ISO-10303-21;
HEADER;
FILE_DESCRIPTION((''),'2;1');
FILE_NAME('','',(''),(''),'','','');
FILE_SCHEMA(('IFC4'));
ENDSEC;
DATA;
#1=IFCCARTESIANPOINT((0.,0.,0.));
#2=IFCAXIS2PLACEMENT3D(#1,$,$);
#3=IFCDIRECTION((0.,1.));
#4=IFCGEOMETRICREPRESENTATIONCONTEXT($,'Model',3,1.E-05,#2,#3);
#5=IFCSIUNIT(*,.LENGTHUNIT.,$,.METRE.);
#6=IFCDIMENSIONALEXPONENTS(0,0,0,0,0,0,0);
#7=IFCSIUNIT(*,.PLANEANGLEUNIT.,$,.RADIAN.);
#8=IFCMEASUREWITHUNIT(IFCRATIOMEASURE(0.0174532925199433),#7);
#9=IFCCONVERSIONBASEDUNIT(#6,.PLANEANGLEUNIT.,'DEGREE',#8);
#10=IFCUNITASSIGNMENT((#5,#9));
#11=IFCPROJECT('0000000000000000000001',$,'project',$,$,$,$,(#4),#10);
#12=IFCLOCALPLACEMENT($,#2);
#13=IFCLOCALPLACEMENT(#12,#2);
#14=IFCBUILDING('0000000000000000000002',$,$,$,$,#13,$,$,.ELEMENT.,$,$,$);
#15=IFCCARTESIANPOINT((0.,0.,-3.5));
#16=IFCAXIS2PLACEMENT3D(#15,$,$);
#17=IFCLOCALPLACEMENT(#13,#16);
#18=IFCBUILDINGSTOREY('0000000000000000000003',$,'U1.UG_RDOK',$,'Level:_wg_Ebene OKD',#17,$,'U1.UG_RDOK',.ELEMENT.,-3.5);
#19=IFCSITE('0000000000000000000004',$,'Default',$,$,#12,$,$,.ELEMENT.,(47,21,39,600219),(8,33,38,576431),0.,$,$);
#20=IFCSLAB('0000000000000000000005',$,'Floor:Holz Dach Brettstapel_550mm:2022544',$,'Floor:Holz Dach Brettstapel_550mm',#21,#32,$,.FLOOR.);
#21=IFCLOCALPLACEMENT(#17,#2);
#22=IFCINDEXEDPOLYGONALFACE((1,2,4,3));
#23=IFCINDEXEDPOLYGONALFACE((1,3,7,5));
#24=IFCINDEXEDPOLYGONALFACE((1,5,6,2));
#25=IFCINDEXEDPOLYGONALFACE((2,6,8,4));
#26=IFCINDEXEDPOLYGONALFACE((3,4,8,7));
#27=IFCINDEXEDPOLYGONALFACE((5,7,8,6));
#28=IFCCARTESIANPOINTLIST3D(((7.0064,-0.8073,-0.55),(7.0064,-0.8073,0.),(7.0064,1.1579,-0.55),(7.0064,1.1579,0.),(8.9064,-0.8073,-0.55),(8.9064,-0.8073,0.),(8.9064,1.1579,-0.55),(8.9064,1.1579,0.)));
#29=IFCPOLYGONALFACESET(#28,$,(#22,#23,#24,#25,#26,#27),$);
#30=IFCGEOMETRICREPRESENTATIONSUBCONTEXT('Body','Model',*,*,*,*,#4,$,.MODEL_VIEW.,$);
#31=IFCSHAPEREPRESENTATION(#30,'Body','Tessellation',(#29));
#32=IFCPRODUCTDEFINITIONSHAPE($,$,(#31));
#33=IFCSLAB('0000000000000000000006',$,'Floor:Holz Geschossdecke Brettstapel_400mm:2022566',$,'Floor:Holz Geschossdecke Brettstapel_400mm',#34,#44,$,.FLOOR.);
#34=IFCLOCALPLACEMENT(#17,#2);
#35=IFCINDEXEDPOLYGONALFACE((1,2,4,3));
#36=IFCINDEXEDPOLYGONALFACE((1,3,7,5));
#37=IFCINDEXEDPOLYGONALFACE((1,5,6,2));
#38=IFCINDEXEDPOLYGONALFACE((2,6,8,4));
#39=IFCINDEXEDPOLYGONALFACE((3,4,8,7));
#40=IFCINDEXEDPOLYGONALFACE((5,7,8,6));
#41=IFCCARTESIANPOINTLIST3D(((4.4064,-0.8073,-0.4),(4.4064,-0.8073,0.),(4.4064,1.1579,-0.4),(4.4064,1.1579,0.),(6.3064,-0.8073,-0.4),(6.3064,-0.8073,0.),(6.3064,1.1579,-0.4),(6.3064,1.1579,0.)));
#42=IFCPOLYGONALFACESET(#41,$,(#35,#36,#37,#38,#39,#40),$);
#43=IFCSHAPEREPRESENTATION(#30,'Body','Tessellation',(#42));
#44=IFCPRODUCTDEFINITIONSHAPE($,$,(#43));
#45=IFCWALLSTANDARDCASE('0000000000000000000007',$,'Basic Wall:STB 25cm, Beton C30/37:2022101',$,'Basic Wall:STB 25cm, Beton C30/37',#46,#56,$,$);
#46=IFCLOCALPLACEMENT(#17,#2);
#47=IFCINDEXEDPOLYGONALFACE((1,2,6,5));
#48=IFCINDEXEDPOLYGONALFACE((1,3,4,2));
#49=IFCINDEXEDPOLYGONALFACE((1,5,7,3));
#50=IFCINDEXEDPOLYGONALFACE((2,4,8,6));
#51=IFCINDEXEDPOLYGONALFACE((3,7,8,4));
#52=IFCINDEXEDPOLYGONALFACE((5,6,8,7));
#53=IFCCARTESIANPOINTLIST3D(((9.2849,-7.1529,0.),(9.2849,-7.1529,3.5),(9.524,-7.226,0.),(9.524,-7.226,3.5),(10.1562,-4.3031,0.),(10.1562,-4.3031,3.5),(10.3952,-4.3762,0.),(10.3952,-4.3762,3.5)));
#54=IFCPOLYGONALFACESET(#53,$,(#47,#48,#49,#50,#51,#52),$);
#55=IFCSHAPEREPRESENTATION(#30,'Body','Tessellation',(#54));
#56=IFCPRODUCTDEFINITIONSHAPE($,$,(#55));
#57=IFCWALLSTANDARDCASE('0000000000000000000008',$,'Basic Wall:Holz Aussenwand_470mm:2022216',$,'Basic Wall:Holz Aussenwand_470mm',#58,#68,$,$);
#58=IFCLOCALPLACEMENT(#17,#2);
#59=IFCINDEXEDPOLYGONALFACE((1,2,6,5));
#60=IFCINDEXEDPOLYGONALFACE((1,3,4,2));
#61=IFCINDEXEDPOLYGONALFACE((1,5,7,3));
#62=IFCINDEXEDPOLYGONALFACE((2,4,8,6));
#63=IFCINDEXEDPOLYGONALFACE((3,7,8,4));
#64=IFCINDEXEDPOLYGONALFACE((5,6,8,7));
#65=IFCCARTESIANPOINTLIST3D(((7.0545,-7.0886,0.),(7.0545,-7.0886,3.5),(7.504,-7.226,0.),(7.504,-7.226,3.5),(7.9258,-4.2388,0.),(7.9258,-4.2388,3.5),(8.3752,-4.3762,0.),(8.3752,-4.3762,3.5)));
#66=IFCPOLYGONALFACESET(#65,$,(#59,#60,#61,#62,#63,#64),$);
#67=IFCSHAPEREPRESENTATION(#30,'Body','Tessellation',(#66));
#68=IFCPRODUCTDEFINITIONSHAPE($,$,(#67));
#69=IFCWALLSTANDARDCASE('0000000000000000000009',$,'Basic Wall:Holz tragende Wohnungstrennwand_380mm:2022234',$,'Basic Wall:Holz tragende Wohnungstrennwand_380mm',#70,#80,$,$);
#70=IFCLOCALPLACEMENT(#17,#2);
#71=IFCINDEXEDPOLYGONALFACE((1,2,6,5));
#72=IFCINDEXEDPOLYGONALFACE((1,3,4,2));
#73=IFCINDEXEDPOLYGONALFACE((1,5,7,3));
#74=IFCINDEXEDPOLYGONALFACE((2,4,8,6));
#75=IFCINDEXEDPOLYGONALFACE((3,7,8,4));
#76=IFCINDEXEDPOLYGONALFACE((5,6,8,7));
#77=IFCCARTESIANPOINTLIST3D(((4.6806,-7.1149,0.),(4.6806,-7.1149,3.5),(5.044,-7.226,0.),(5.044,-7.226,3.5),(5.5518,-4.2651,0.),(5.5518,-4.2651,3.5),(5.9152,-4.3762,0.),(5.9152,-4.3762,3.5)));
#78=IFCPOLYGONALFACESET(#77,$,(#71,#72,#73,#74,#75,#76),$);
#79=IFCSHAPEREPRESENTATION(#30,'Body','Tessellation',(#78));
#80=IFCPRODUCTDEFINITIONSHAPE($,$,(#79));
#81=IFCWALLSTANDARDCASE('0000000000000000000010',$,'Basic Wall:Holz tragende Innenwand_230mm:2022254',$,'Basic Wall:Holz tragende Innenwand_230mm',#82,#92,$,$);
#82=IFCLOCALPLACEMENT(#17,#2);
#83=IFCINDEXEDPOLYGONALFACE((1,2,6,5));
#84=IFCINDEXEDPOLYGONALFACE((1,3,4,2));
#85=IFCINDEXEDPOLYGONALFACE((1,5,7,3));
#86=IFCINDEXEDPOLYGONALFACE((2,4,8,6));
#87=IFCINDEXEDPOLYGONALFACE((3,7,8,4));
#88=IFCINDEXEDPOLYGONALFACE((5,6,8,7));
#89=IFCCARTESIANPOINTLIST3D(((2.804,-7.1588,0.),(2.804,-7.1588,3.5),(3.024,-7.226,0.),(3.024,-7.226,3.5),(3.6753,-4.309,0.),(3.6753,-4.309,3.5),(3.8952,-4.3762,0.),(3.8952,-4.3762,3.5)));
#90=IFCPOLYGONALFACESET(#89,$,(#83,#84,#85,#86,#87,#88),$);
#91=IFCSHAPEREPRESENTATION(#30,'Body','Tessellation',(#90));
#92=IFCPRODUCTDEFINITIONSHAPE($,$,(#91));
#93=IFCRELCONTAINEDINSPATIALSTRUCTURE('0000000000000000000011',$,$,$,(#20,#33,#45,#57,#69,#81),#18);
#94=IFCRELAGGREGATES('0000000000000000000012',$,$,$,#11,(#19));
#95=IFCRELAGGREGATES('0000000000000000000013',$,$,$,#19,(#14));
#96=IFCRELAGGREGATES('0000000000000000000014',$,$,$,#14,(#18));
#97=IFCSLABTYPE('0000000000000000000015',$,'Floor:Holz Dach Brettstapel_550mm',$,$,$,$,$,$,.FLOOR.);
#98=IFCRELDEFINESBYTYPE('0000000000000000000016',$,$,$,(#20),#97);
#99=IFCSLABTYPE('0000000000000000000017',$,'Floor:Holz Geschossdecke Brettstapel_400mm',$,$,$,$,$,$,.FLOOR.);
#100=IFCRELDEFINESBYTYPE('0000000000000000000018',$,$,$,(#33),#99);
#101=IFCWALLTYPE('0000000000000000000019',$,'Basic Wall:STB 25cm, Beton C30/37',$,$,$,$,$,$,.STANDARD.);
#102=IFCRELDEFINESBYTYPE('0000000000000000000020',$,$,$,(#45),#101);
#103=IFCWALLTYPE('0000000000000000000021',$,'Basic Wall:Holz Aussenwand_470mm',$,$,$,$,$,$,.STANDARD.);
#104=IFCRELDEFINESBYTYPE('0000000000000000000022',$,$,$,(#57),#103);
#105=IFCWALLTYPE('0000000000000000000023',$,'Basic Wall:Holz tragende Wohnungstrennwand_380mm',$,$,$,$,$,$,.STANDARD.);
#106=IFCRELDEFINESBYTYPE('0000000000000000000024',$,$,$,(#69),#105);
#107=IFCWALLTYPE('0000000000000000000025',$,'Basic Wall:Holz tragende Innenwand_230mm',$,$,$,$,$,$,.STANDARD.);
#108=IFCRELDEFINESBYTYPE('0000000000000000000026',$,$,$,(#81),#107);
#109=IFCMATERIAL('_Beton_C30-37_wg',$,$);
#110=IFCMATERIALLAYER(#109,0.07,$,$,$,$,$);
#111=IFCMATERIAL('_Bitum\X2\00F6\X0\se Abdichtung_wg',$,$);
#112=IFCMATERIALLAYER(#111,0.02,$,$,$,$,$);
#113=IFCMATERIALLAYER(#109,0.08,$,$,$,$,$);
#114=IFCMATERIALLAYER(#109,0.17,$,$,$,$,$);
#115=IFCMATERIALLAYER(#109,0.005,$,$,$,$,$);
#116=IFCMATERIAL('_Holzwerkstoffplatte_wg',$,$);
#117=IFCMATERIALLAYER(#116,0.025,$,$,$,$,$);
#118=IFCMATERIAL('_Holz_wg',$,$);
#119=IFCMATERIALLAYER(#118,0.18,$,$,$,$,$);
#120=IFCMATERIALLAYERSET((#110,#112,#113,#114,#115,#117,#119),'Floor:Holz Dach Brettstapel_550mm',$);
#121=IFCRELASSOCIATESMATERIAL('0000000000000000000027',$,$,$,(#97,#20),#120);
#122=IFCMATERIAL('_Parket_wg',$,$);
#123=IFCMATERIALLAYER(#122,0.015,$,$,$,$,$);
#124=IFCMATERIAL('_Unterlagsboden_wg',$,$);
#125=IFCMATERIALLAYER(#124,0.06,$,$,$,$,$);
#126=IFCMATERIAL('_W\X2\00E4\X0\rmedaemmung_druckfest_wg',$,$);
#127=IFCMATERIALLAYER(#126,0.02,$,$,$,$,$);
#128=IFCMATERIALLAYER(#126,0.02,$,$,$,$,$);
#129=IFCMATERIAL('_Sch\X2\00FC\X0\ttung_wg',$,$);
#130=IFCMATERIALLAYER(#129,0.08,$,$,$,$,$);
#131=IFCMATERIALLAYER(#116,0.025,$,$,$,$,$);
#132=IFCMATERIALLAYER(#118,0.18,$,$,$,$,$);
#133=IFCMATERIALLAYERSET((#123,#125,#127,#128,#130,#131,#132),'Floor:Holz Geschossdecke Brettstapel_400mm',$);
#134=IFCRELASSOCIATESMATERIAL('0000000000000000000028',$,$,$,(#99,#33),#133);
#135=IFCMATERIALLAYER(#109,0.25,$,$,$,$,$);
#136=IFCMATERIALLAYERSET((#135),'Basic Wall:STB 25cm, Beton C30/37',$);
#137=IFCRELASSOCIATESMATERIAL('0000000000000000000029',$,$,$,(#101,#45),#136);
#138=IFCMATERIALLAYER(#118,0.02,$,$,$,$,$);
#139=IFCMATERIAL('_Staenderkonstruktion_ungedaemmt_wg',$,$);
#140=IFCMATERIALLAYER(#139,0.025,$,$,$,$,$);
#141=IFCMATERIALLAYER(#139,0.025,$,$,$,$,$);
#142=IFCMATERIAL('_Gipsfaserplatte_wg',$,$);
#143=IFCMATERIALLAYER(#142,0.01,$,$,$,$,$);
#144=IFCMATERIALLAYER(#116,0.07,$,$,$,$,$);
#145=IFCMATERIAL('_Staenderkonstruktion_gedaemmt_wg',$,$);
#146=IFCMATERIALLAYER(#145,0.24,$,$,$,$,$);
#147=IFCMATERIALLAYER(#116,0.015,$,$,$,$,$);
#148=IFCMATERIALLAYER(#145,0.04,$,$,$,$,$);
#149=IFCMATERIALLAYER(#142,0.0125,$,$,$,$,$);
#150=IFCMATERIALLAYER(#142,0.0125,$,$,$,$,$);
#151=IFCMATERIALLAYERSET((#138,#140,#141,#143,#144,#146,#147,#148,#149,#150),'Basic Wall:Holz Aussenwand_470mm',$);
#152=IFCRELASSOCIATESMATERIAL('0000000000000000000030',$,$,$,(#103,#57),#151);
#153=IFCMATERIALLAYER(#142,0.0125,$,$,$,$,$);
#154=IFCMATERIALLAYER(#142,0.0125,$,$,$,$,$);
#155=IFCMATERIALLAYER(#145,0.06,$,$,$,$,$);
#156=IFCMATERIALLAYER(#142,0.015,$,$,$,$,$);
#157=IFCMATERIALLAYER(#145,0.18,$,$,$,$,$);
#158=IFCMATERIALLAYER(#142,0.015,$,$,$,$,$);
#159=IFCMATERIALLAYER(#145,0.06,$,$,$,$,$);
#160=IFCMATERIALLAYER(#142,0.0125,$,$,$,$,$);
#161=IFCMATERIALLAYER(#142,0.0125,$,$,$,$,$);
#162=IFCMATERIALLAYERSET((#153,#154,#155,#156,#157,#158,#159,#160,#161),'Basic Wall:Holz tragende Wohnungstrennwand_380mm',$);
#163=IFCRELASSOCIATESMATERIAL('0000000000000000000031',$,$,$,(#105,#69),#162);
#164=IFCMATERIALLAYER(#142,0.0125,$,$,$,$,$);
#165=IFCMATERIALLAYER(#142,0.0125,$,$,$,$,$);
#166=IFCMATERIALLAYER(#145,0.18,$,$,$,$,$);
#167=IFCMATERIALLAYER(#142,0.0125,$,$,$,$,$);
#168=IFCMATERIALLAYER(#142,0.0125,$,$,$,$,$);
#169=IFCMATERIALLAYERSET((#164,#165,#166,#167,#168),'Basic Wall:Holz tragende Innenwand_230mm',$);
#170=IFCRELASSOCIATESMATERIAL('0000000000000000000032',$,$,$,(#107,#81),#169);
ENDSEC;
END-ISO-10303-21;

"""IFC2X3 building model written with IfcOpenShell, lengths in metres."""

from ifc_helpers import new_model, entity, si_unit, converted_unit, direction, frame, frame_2d, origin, origin_2d_with_axis, place, context, subcontext, project, spatial, rectangle, extrude, material, layer, layer_set, layer_usage, type_object, element, save


model = new_model("IFC2X3")

# Units and contexts
model_context = context("Model", 3, precision=1e-05, world=origin(), true_north=direction((0.0, 1.0)))
body_context = subcontext(model_context, "Body", "Model", "MODEL_VIEW")
ifc_project = project(units=[si_unit("LENGTHUNIT", "METRE"), converted_unit("PLANEANGLEUNIT", "DEGREE", entity("IfcRatioMeasure", 0.0174532925199433), si_unit("PLANEANGLEUNIT", "RADIAN"), dimensions=[0, 0, 0, 0, 0, 0, 0])], contexts=[model_context])

# Site, building, storey
site_placement = place(None, origin())
site = spatial("IfcSite", under=ifc_project, at=site_placement, Name="Default", CompositionType="ELEMENT", RefLatitude=(47, 21, 39, 600219), RefLongitude=(8, 33, 38, 576431), RefElevation=0.0)
building_placement = place(site_placement, origin())
building = spatial("IfcBuilding", under=site, at=building_placement, CompositionType="ELEMENT")
storey_placement = place(building_placement, frame((0.0, 0.0, -3.5)))
storey = spatial("IfcBuildingStorey", under=building, at=storey_placement, Name="U1.UG_RDOK", ObjectType="Level:_wg_Ebene OKD", LongName="U1.UG_RDOK", CompositionType="ELEMENT", Elevation=-3.5)

# Shared definitions
ifc_material_1 = material(Name="_Beton_C30-37_wg")
ifc_material_2 = material(Name="_Holz_wg")

# Slabs
ifc_layer_1 = layer(ifc_material_1, 0.07)
ifc_material_3 = material(Name="_Bitumöse Abdichtung_wg")
ifc_layer_2 = layer(ifc_material_3, 0.02)
ifc_layer_3 = layer(ifc_material_1, 0.08)
ifc_layer_4 = layer(ifc_material_1, 0.17)
ifc_layer_5 = layer(ifc_material_1, 0.005)
ifc_material_4 = material(Name="_Holzwerkstoffplatte_wg")
ifc_layer_6 = layer(ifc_material_4, 0.025)
ifc_layer_7 = layer(ifc_material_2, 0.18)
ifc_layer_set_1 = layer_set([ifc_layer_1, ifc_layer_2, ifc_layer_3, ifc_layer_4, ifc_layer_5, ifc_layer_6, ifc_layer_7], Name="Floor:Holz Dach Brettstapel_550mm")
ifc_layer_usage_1 = layer_usage(ifc_layer_set_1, "AXIS3", "POSITIVE", 0.0)
slab_type_1 = type_object("IfcSlabType", Name="Floor:Holz Dach Brettstapel_550mm", PredefinedType="FLOOR", material=ifc_layer_set_1)
slab_1_placement = place(storey_placement, origin())
element("IfcSlab", 1, at=slab_1_placement, inside=storey, type_object=slab_type_1, material=ifc_layer_usage_1, Name="Floor:Holz Dach Brettstapel_550mm:2022544", ObjectType="Floor:Holz Dach Brettstapel_550mm", PredefinedType="FLOOR", context=body_context, shape_type="SweptSolid", body=[
    extrude(rectangle(XDim=1.9652, YDim=1.9, at=origin_2d_with_axis()), frame((7.9564, 0.1753, 0.0), z_axis=(0.0, 0.0, -1.0), x_axis=(0.0, 1.0, 0.0)), (0.0, 0.0, 1.0), 0.55),
])
ifc_material_5 = material(Name="_Parket_wg")
ifc_layer_8 = layer(ifc_material_5, 0.015)
ifc_material_6 = material(Name="_Unterlagsboden_wg")
ifc_layer_9 = layer(ifc_material_6, 0.06)
ifc_material_7 = material(Name="_Wärmedaemmung_druckfest_wg")
ifc_layer_10 = layer(ifc_material_7, 0.02)
ifc_layer_11 = layer(ifc_material_7, 0.02)
ifc_material_8 = material(Name="_Schüttung_wg")
ifc_layer_12 = layer(ifc_material_8, 0.08)
ifc_layer_13 = layer(ifc_material_4, 0.025)
ifc_layer_14 = layer(ifc_material_2, 0.18)
ifc_layer_set_2 = layer_set([ifc_layer_8, ifc_layer_9, ifc_layer_10, ifc_layer_11, ifc_layer_12, ifc_layer_13, ifc_layer_14], Name="Floor:Holz Geschossdecke Brettstapel_400mm")
ifc_layer_usage_2 = layer_usage(ifc_layer_set_2, "AXIS3", "POSITIVE", 0.0)
slab_type_2 = type_object("IfcSlabType", Name="Floor:Holz Geschossdecke Brettstapel_400mm", PredefinedType="FLOOR", material=ifc_layer_set_2)
slab_2_placement = place(storey_placement, origin())
element("IfcSlab", 2, at=slab_2_placement, inside=storey, type_object=slab_type_2, material=ifc_layer_usage_2, Name="Floor:Holz Geschossdecke Brettstapel_400mm:2022566", ObjectType="Floor:Holz Geschossdecke Brettstapel_400mm", PredefinedType="FLOOR", context=body_context, shape_type="SweptSolid", body=[
    extrude(rectangle(XDim=1.9652, YDim=1.9, at=origin_2d_with_axis()), frame((5.3564, 0.1753, 0.0), z_axis=(0.0, 0.0, -1.0), x_axis=(0.0, 1.0, 0.0)), (0.0, 0.0, 1.0), 0.4),
])

# Walls
ifc_layer_15 = layer(ifc_material_1, 0.25)
ifc_layer_set_3 = layer_set([ifc_layer_15], Name="Basic Wall:STB 25cm, Beton C30/37")
ifc_layer_usage_3 = layer_usage(ifc_layer_set_3, "AXIS2", "NEGATIVE", 0.125)
wall_type_1 = type_object("IfcWallType", Name="Basic Wall:STB 25cm, Beton C30/37", PredefinedType="STANDARD", material=ifc_layer_set_3)
wall_1_placement = place(storey_placement, frame((10.2757, -4.3397, 0.0), z_axis=(0.0, 0.0, 1.0), x_axis=(-0.292372, -0.956305, 0.0)))
element("IfcWallStandardCase", 3, at=wall_1_placement, inside=storey, type_object=wall_type_1, material=ifc_layer_usage_3, Name="Basic Wall:STB 25cm, Beton C30/37:2022101", ObjectType="Basic Wall:STB 25cm, Beton C30/37", context=body_context, shape_type="SweptSolid", body=[
    extrude(rectangle(XDim=2.98, YDim=0.25, at=frame_2d((1.49, 0.0), x_axis=(-1.0, 0.0))), origin(), (0.0, 0.0, 1.0), 3.5),
])
ifc_layer_16 = layer(ifc_material_2, 0.02)
ifc_material_9 = material(Name="_Staenderkonstruktion_ungedaemmt_wg")
ifc_layer_17 = layer(ifc_material_9, 0.025)
ifc_layer_18 = layer(ifc_material_9, 0.025)
ifc_material_10 = material(Name="_Gipsfaserplatte_wg")
ifc_layer_19 = layer(ifc_material_10, 0.01)
ifc_layer_20 = layer(ifc_material_4, 0.07)
ifc_material_11 = material(Name="_Staenderkonstruktion_gedaemmt_wg")
ifc_layer_21 = layer(ifc_material_11, 0.24)
ifc_layer_22 = layer(ifc_material_4, 0.015)
ifc_layer_23 = layer(ifc_material_11, 0.04)
ifc_layer_24 = layer(ifc_material_10, 0.0125)
ifc_layer_25 = layer(ifc_material_10, 0.0125)
ifc_layer_set_4 = layer_set([ifc_layer_16, ifc_layer_17, ifc_layer_18, ifc_layer_19, ifc_layer_20, ifc_layer_21, ifc_layer_22, ifc_layer_23, ifc_layer_24, ifc_layer_25], Name="Basic Wall:Holz Aussenwand_470mm")
ifc_layer_usage_4 = layer_usage(ifc_layer_set_4, "AXIS2", "NEGATIVE", 0.235)
wall_type_2 = type_object("IfcWallType", Name="Basic Wall:Holz Aussenwand_470mm", PredefinedType="STANDARD", material=ifc_layer_set_4)
wall_2_placement = place(storey_placement, frame((8.1505, -4.3075, 0.0), z_axis=(0.0, 0.0, 1.0), x_axis=(-0.292372, -0.956305, 0.0)))
element("IfcWallStandardCase", 4, at=wall_2_placement, inside=storey, type_object=wall_type_2, material=ifc_layer_usage_4, Name="Basic Wall:Holz Aussenwand_470mm:2022216", ObjectType="Basic Wall:Holz Aussenwand_470mm", context=body_context, shape_type="SweptSolid", body=[
    extrude(rectangle(XDim=2.98, YDim=0.47, at=frame_2d((1.49, 0.0), x_axis=(-1.0, 0.0))), origin(), (0.0, 0.0, 1.0), 3.5),
])
ifc_layer_26 = layer(ifc_material_10, 0.0125)
ifc_layer_27 = layer(ifc_material_10, 0.0125)
ifc_layer_28 = layer(ifc_material_11, 0.06)
ifc_layer_29 = layer(ifc_material_10, 0.015)
ifc_layer_30 = layer(ifc_material_11, 0.18)
ifc_layer_31 = layer(ifc_material_10, 0.015)
ifc_layer_32 = layer(ifc_material_11, 0.06)
ifc_layer_33 = layer(ifc_material_10, 0.0125)
ifc_layer_34 = layer(ifc_material_10, 0.0125)
ifc_layer_set_5 = layer_set([ifc_layer_26, ifc_layer_27, ifc_layer_28, ifc_layer_29, ifc_layer_30, ifc_layer_31, ifc_layer_32, ifc_layer_33, ifc_layer_34], Name="Basic Wall:Holz tragende Wohnungstrennwand_380mm")
ifc_layer_usage_5 = layer_usage(ifc_layer_set_5, "AXIS2", "NEGATIVE", 0.19)
wall_type_3 = type_object("IfcWallType", Name="Basic Wall:Holz tragende Wohnungstrennwand_380mm", PredefinedType="STANDARD", material=ifc_layer_set_5)
wall_3_placement = place(storey_placement, frame((5.7335, -4.3207, 0.0), z_axis=(0.0, 0.0, 1.0), x_axis=(-0.292372, -0.956305, 0.0)))
element("IfcWallStandardCase", 5, at=wall_3_placement, inside=storey, type_object=wall_type_3, material=ifc_layer_usage_5, Name="Basic Wall:Holz tragende Wohnungstrennwand_380mm:2022234", ObjectType="Basic Wall:Holz tragende Wohnungstrennwand_380mm", context=body_context, shape_type="SweptSolid", body=[
    extrude(rectangle(XDim=2.98, YDim=0.38, at=frame_2d((1.49, 0.0), x_axis=(-1.0, 0.0))), origin(), (0.0, 0.0, 1.0), 3.5),
])
ifc_layer_35 = layer(ifc_material_10, 0.0125)
ifc_layer_36 = layer(ifc_material_10, 0.0125)
ifc_layer_37 = layer(ifc_material_11, 0.18)
ifc_layer_38 = layer(ifc_material_10, 0.0125)
ifc_layer_39 = layer(ifc_material_10, 0.0125)
ifc_layer_set_6 = layer_set([ifc_layer_35, ifc_layer_36, ifc_layer_37, ifc_layer_38, ifc_layer_39], Name="Basic Wall:Holz tragende Innenwand_230mm")
ifc_layer_usage_6 = layer_usage(ifc_layer_set_6, "AXIS2", "NEGATIVE", 0.115)
wall_type_4 = type_object("IfcWallType", Name="Basic Wall:Holz tragende Innenwand_230mm", PredefinedType="STANDARD", material=ifc_layer_set_6)
wall_4_placement = place(storey_placement, frame((3.7853, -4.3426, 0.0), z_axis=(0.0, 0.0, 1.0), x_axis=(-0.292372, -0.956305, 0.0)))
element("IfcWallStandardCase", 6, at=wall_4_placement, inside=storey, type_object=wall_type_4, material=ifc_layer_usage_6, Name="Basic Wall:Holz tragende Innenwand_230mm:2022254", ObjectType="Basic Wall:Holz tragende Innenwand_230mm", context=body_context, shape_type="SweptSolid", body=[
    extrude(rectangle(XDim=2.98, YDim=0.23, at=frame_2d((1.49, 0.0), x_axis=(-1.0, 0.0))), origin(), (0.0, 0.0, 1.0), 3.5),
])

save(model, "model.ifc")
